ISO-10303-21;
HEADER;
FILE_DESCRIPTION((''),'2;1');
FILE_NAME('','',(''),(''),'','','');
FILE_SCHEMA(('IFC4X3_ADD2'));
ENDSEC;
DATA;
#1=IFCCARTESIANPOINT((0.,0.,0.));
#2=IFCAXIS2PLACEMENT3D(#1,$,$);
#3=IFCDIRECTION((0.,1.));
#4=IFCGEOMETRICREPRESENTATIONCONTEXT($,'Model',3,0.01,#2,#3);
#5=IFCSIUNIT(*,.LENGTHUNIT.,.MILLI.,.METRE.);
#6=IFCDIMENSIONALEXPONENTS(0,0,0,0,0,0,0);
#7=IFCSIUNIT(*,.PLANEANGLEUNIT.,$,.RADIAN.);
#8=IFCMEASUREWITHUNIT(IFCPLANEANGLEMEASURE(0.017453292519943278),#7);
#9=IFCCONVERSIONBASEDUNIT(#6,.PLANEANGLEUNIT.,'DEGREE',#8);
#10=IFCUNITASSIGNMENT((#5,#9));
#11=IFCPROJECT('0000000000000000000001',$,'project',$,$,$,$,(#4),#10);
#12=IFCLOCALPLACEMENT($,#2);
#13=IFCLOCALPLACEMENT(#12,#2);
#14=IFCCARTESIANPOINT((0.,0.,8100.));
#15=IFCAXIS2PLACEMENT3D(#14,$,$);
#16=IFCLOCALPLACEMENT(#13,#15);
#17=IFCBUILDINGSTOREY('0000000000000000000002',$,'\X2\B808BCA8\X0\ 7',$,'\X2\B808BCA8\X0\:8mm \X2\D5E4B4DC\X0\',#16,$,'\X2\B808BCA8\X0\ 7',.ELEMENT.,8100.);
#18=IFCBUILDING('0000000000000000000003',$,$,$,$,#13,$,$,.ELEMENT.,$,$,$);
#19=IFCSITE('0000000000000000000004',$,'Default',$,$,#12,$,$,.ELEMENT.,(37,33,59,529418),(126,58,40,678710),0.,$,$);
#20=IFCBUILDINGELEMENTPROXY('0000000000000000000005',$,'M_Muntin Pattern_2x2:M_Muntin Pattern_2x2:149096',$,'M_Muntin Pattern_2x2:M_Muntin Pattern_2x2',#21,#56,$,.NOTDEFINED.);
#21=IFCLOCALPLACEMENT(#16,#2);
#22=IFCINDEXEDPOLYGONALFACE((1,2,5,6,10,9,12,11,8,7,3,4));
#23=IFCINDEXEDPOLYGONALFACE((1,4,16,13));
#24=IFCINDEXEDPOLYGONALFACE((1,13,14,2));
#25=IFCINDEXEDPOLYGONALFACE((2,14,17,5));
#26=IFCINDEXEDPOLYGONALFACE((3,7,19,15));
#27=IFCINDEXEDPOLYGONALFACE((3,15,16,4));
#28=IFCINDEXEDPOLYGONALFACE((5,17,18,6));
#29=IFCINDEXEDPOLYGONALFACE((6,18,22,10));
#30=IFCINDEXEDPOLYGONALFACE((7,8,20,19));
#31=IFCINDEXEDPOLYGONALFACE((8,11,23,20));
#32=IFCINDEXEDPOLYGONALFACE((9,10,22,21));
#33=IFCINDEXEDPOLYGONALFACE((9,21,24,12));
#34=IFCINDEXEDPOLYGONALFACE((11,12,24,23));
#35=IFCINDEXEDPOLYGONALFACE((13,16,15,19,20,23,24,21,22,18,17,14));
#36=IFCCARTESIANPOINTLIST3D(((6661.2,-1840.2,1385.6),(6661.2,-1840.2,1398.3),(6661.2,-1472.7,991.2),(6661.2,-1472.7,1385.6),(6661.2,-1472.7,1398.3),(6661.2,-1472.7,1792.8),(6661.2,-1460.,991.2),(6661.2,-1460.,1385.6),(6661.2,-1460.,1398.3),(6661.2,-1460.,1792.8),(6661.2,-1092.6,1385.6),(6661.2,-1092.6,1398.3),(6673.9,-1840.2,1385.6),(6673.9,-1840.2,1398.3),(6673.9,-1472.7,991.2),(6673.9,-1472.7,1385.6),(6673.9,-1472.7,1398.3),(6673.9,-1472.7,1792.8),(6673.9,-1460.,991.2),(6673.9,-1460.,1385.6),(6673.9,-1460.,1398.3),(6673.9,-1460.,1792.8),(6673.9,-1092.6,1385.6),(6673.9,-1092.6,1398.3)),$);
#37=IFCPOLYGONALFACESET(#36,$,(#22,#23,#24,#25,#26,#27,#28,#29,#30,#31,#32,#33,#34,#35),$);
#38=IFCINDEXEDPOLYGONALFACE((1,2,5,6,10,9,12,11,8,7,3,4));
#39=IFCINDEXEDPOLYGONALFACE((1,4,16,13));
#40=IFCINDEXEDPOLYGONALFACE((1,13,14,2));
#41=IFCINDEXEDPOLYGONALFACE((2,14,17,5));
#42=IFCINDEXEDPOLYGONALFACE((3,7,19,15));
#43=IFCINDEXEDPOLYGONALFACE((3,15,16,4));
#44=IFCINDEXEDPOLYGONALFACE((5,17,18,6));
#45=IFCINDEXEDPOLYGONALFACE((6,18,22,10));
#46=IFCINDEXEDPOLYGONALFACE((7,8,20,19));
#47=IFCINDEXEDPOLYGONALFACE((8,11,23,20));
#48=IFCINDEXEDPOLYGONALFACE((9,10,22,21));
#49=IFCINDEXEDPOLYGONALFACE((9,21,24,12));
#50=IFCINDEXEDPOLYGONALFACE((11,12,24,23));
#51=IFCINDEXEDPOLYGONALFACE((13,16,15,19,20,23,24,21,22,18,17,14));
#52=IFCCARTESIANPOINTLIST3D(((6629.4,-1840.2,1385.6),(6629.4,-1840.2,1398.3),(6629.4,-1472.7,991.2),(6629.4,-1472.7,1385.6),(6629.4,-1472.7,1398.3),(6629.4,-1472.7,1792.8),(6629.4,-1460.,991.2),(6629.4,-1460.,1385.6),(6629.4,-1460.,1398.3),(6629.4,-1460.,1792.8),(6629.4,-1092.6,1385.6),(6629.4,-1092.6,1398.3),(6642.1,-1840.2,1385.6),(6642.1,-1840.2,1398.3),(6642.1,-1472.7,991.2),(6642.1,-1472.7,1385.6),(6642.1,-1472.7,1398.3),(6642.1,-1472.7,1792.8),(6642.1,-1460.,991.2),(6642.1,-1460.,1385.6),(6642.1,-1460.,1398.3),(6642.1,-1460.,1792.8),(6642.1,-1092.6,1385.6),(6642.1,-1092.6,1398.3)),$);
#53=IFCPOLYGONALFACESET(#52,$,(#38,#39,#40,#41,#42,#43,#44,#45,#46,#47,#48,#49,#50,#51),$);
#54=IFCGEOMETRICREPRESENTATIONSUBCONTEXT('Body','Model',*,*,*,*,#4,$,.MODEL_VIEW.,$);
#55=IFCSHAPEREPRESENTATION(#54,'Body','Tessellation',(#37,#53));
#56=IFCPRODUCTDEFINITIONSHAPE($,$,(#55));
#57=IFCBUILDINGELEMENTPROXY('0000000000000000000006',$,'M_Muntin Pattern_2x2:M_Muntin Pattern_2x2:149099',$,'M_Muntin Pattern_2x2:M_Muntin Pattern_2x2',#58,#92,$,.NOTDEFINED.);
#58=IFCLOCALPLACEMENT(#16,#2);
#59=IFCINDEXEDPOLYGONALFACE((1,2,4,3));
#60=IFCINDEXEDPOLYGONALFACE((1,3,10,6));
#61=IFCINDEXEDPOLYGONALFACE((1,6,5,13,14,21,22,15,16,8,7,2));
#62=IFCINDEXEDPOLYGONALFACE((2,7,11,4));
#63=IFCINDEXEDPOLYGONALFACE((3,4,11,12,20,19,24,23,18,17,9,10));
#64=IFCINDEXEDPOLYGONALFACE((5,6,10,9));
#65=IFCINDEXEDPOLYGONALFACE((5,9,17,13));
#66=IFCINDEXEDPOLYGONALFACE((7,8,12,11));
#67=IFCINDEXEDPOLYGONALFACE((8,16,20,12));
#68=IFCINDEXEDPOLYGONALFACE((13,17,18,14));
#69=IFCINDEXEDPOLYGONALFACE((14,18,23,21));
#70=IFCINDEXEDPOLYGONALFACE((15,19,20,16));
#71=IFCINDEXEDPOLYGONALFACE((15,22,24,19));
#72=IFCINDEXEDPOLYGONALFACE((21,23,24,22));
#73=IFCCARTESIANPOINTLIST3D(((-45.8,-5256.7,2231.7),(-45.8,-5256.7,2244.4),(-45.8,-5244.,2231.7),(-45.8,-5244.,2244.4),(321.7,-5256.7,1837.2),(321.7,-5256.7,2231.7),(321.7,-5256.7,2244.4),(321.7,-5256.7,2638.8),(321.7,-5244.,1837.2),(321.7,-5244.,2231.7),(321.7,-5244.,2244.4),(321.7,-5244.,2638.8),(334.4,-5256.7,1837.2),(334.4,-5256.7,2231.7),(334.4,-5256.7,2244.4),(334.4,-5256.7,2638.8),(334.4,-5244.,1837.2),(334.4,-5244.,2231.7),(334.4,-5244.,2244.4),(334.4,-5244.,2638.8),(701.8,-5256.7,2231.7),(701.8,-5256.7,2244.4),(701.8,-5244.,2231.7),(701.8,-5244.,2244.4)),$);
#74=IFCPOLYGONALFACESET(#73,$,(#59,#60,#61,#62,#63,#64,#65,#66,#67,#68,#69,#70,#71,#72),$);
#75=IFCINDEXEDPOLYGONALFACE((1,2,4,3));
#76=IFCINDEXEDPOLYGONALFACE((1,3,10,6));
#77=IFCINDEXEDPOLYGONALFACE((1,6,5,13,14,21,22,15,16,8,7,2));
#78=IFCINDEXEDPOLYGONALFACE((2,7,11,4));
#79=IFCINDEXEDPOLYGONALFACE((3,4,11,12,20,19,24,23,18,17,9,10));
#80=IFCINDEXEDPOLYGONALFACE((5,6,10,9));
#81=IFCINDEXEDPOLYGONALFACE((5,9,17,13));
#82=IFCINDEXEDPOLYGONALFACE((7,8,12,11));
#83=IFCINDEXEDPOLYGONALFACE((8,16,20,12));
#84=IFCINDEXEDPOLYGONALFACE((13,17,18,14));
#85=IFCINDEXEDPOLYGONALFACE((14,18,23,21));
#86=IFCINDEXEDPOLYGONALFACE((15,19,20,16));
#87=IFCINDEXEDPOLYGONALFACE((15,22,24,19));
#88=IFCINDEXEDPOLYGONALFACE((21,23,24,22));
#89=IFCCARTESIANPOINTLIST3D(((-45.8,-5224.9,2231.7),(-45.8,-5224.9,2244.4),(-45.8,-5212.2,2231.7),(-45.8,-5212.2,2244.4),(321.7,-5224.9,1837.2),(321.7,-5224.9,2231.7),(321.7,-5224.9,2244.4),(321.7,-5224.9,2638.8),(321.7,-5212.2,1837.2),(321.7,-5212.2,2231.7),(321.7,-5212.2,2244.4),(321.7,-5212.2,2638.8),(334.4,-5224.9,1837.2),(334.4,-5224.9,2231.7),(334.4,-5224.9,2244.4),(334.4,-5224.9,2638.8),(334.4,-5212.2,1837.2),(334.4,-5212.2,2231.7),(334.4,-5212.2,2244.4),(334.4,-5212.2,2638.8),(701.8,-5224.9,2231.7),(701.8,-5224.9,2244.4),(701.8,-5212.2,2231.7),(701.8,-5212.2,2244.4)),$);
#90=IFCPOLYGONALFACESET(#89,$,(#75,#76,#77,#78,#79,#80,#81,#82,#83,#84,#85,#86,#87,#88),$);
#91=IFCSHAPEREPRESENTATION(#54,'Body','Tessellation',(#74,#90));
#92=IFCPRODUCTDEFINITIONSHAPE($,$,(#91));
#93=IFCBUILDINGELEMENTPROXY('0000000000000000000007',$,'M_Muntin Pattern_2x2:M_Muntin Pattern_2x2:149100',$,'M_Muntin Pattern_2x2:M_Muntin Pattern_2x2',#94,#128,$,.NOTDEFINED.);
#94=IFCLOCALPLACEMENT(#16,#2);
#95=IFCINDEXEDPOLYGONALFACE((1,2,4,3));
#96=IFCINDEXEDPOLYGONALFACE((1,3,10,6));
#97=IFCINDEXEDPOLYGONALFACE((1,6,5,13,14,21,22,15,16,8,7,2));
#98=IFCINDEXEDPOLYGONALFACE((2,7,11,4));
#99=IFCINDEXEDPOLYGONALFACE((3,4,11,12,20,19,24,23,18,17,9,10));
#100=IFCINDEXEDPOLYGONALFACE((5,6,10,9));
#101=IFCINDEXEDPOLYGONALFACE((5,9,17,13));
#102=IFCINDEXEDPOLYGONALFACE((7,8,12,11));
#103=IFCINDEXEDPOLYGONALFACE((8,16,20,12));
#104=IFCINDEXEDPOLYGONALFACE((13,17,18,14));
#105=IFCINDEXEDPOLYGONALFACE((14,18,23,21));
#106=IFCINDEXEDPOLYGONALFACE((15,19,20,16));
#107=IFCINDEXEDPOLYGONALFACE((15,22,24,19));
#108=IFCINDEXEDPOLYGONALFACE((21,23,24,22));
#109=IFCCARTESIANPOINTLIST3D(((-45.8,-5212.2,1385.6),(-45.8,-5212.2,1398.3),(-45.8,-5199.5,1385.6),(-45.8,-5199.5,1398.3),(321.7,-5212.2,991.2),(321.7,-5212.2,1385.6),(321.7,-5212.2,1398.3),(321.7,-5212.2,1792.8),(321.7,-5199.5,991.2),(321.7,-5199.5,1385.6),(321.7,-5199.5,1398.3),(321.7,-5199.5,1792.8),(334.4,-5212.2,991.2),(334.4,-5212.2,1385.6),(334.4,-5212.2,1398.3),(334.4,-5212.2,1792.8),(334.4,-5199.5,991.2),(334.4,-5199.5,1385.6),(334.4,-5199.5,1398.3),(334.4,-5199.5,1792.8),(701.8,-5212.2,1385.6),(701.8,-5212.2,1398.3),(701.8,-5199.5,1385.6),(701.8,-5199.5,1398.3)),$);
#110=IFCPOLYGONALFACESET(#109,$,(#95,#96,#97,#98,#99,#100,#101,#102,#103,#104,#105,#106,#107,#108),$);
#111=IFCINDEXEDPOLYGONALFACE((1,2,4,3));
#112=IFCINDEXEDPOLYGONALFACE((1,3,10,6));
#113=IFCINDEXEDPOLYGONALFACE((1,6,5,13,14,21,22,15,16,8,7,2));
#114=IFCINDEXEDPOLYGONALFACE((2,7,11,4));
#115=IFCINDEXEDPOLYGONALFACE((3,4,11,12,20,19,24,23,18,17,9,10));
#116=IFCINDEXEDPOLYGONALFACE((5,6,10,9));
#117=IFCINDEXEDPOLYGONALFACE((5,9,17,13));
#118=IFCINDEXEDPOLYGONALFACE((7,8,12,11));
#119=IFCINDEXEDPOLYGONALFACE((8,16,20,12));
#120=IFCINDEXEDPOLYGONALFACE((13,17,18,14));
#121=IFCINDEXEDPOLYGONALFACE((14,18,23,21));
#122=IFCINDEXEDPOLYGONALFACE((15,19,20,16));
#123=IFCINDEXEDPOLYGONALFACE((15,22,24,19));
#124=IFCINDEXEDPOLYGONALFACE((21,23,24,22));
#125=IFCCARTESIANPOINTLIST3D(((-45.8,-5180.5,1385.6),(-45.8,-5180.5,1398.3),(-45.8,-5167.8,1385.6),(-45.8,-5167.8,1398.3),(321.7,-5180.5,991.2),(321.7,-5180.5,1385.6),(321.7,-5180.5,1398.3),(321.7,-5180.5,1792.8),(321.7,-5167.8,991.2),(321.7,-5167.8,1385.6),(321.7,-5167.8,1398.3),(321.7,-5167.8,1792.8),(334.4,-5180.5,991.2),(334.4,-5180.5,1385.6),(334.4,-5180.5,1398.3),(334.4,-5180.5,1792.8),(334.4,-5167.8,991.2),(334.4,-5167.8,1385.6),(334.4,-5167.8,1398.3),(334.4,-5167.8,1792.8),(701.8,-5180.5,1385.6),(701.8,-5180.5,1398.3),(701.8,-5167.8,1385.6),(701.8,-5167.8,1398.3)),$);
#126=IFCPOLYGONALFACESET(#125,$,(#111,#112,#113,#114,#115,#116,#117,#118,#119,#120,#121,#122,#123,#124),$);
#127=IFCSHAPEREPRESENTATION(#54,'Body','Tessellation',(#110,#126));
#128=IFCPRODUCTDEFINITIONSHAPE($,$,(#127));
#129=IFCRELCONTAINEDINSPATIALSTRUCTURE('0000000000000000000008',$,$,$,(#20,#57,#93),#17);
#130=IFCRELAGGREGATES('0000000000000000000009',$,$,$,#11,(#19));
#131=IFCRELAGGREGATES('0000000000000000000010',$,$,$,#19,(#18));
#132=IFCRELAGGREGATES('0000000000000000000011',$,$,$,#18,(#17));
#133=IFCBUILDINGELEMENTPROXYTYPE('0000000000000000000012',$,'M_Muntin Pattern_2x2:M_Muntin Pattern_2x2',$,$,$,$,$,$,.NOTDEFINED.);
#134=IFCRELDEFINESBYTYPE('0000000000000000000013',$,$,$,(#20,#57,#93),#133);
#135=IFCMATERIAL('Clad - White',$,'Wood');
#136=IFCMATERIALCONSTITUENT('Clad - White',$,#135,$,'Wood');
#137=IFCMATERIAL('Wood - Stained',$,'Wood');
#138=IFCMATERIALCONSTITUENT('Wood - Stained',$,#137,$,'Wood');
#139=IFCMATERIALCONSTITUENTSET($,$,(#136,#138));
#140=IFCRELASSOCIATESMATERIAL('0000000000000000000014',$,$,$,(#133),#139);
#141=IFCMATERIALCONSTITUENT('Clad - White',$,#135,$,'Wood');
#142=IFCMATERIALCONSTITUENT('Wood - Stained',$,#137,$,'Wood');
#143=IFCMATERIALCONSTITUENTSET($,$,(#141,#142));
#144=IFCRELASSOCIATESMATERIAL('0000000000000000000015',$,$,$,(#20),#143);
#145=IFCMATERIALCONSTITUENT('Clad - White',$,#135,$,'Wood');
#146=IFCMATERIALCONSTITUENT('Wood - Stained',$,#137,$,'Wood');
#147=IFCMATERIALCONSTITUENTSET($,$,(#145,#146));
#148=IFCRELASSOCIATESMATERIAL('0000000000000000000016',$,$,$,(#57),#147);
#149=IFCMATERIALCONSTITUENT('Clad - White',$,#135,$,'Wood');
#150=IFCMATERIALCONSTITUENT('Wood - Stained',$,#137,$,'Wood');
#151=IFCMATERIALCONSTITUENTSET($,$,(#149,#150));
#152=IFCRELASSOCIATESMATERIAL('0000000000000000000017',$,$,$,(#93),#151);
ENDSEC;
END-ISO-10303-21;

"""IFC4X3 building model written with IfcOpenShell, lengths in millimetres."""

from ifc_helpers import new_model, entity, si_unit, converted_unit, direction, frame, origin, place, context, subcontext, project, spatial, polyline, outline, extrude, source, transform, mapped, material, constituent, constituent_set, type_object, type_shapes, element, save


model = new_model("IFC4X3")

# Units and contexts
model_context = context("Model", 3, precision=0.01, world=origin(), true_north=direction((0.0, 1.0)))
body_context = subcontext(model_context, "Body", "Model", "MODEL_VIEW")
ifc_project = project(units=[si_unit("LENGTHUNIT", "METRE", prefix="MILLI"), converted_unit("PLANEANGLEUNIT", "DEGREE", entity("IfcPlaneAngleMeasure", 0.017453292519943278), si_unit("PLANEANGLEUNIT", "RADIAN"), dimensions=[0, 0, 0, 0, 0, 0, 0])], contexts=[model_context])

# Site, building, storey
site_placement = place(None, origin())
site = spatial("IfcSite", under=ifc_project, at=site_placement, Name="Default", CompositionType="ELEMENT", RefLatitude=(37, 33, 59, 529418), RefLongitude=(126, 58, 40, 678710), RefElevation=0.0)
building_placement = place(site_placement, origin())
building = spatial("IfcBuilding", under=site, at=building_placement, CompositionType="ELEMENT")
storey_placement = place(building_placement, frame((0.0, 0.0, 8100.0)))
storey = spatial("IfcBuildingStorey", under=building, at=storey_placement, Name="레벨 7", ObjectType="레벨:8mm 헤드", LongName="레벨 7", CompositionType="ELEMENT", Elevation=8100.0)

# Building element proxies
ifc_material_1 = material(Name="Clad - White", Category="Wood")
ifc_material_2 = material(Name="Wood - Stained", Category="Wood")
ifc_constituent_1 = constituent(ifc_material_1, Name="Clad - White", Category="Wood")
ifc_constituent_2 = constituent(ifc_material_2, Name="Wood - Stained", Category="Wood")
ifc_constituent_set_1 = constituent_set(constituents=[ifc_constituent_1, ifc_constituent_2])
building_element_proxy_type_1 = type_object("IfcBuildingElementProxyType", Name="M_Muntin Pattern_2x2:M_Muntin Pattern_2x2", PredefinedType="NOTDEFINED", material=ifc_constituent_set_1)
shared_shape_1 = source(origin(), body_context, "Body", "SweptSolid", [
    extrude(outline(polyline([(6.4, -6.4), (400.8, -6.4), (400.8, 6.3), (6.4, 6.3), (6.4, 373.8), (-6.3, 373.8), (-6.3, 6.3), (-400.8, 6.3), (-400.8, -6.4), (-6.3, -6.4), (-6.3, -373.8), (6.4, -373.8), (6.4, -6.4)])), frame((0.0, 9.5, 400.8), z_axis=(0.0, 1.0, 0.0), x_axis=(0.0, 0.0, 1.0)), (0.0, 0.0, 1.0), 12.7),
    extrude(outline(polyline([(6.4, -6.4), (400.8, -6.4), (400.8, 6.3), (6.4, 6.3), (6.4, 373.8), (-6.3, 373.8), (-6.3, 6.3), (-400.8, 6.3), (-400.8, -6.4), (-6.3, -6.4), (-6.3, -373.8), (6.4, -373.8), (6.4, -6.4)])), frame((0.0, -22.2, 400.8), z_axis=(0.0, 1.0, 0.0), x_axis=(0.0, 0.0, 1.0)), (0.0, 0.0, 1.0), 12.7),
])
type_shapes(building_element_proxy_type_1, [shared_shape_1])
ifc_constituent_3 = constituent(ifc_material_1, Name="Clad - White", Category="Wood")
ifc_constituent_4 = constituent(ifc_material_2, Name="Wood - Stained", Category="Wood")
ifc_constituent_set_2 = constituent_set(constituents=[ifc_constituent_3, ifc_constituent_4])
proxy_1_placement = place(storey_placement, frame((6651.7, -1466.4, 991.2), z_axis=(0.0, 0.0, 1.0), x_axis=(0.0, -1.0, 0.0)))
element("IfcBuildingElementProxy", 1, at=proxy_1_placement, inside=storey, type_object=building_element_proxy_type_1, material=ifc_constituent_set_2, Name="M_Muntin Pattern_2x2:M_Muntin Pattern_2x2:149096", ObjectType="M_Muntin Pattern_2x2:M_Muntin Pattern_2x2", PredefinedType="NOTDEFINED", context=body_context, shape_type="MappedRepresentation", body=[
    mapped(shared_shape_1, transform((0.0, 0.0, 0.0), scale=1.0)),
])
ifc_constituent_5 = constituent(ifc_material_1, Name="Clad - White", Category="Wood")
ifc_constituent_6 = constituent(ifc_material_2, Name="Wood - Stained", Category="Wood")
ifc_constituent_set_3 = constituent_set(constituents=[ifc_constituent_5, ifc_constituent_6])
proxy_2_placement = place(storey_placement, frame((328.0, -5234.4, 1837.2), z_axis=(0.0, 0.0, 1.0), x_axis=(-1.0, 0.0, 0.0)))
element("IfcBuildingElementProxy", 2, at=proxy_2_placement, inside=storey, type_object=building_element_proxy_type_1, material=ifc_constituent_set_3, Name="M_Muntin Pattern_2x2:M_Muntin Pattern_2x2:149099", ObjectType="M_Muntin Pattern_2x2:M_Muntin Pattern_2x2", PredefinedType="NOTDEFINED", context=body_context, shape_type="MappedRepresentation", body=[
    mapped(shared_shape_1, transform((0.0, 0.0, 0.0), scale=1.0)),
])
ifc_constituent_7 = constituent(ifc_material_1, Name="Clad - White", Category="Wood")
ifc_constituent_8 = constituent(ifc_material_2, Name="Wood - Stained", Category="Wood")
ifc_constituent_set_4 = constituent_set(constituents=[ifc_constituent_7, ifc_constituent_8])
proxy_3_placement = place(storey_placement, frame((328.0, -5190.0, 991.2), z_axis=(0.0, 0.0, 1.0), x_axis=(-1.0, 0.0, 0.0)))
element("IfcBuildingElementProxy", 3, at=proxy_3_placement, inside=storey, type_object=building_element_proxy_type_1, material=ifc_constituent_set_4, Name="M_Muntin Pattern_2x2:M_Muntin Pattern_2x2:149100", ObjectType="M_Muntin Pattern_2x2:M_Muntin Pattern_2x2", PredefinedType="NOTDEFINED", context=body_context, shape_type="MappedRepresentation", body=[
    mapped(shared_shape_1, transform((0.0, 0.0, 0.0), scale=1.0)),
])

save(model, "model.ifc")
